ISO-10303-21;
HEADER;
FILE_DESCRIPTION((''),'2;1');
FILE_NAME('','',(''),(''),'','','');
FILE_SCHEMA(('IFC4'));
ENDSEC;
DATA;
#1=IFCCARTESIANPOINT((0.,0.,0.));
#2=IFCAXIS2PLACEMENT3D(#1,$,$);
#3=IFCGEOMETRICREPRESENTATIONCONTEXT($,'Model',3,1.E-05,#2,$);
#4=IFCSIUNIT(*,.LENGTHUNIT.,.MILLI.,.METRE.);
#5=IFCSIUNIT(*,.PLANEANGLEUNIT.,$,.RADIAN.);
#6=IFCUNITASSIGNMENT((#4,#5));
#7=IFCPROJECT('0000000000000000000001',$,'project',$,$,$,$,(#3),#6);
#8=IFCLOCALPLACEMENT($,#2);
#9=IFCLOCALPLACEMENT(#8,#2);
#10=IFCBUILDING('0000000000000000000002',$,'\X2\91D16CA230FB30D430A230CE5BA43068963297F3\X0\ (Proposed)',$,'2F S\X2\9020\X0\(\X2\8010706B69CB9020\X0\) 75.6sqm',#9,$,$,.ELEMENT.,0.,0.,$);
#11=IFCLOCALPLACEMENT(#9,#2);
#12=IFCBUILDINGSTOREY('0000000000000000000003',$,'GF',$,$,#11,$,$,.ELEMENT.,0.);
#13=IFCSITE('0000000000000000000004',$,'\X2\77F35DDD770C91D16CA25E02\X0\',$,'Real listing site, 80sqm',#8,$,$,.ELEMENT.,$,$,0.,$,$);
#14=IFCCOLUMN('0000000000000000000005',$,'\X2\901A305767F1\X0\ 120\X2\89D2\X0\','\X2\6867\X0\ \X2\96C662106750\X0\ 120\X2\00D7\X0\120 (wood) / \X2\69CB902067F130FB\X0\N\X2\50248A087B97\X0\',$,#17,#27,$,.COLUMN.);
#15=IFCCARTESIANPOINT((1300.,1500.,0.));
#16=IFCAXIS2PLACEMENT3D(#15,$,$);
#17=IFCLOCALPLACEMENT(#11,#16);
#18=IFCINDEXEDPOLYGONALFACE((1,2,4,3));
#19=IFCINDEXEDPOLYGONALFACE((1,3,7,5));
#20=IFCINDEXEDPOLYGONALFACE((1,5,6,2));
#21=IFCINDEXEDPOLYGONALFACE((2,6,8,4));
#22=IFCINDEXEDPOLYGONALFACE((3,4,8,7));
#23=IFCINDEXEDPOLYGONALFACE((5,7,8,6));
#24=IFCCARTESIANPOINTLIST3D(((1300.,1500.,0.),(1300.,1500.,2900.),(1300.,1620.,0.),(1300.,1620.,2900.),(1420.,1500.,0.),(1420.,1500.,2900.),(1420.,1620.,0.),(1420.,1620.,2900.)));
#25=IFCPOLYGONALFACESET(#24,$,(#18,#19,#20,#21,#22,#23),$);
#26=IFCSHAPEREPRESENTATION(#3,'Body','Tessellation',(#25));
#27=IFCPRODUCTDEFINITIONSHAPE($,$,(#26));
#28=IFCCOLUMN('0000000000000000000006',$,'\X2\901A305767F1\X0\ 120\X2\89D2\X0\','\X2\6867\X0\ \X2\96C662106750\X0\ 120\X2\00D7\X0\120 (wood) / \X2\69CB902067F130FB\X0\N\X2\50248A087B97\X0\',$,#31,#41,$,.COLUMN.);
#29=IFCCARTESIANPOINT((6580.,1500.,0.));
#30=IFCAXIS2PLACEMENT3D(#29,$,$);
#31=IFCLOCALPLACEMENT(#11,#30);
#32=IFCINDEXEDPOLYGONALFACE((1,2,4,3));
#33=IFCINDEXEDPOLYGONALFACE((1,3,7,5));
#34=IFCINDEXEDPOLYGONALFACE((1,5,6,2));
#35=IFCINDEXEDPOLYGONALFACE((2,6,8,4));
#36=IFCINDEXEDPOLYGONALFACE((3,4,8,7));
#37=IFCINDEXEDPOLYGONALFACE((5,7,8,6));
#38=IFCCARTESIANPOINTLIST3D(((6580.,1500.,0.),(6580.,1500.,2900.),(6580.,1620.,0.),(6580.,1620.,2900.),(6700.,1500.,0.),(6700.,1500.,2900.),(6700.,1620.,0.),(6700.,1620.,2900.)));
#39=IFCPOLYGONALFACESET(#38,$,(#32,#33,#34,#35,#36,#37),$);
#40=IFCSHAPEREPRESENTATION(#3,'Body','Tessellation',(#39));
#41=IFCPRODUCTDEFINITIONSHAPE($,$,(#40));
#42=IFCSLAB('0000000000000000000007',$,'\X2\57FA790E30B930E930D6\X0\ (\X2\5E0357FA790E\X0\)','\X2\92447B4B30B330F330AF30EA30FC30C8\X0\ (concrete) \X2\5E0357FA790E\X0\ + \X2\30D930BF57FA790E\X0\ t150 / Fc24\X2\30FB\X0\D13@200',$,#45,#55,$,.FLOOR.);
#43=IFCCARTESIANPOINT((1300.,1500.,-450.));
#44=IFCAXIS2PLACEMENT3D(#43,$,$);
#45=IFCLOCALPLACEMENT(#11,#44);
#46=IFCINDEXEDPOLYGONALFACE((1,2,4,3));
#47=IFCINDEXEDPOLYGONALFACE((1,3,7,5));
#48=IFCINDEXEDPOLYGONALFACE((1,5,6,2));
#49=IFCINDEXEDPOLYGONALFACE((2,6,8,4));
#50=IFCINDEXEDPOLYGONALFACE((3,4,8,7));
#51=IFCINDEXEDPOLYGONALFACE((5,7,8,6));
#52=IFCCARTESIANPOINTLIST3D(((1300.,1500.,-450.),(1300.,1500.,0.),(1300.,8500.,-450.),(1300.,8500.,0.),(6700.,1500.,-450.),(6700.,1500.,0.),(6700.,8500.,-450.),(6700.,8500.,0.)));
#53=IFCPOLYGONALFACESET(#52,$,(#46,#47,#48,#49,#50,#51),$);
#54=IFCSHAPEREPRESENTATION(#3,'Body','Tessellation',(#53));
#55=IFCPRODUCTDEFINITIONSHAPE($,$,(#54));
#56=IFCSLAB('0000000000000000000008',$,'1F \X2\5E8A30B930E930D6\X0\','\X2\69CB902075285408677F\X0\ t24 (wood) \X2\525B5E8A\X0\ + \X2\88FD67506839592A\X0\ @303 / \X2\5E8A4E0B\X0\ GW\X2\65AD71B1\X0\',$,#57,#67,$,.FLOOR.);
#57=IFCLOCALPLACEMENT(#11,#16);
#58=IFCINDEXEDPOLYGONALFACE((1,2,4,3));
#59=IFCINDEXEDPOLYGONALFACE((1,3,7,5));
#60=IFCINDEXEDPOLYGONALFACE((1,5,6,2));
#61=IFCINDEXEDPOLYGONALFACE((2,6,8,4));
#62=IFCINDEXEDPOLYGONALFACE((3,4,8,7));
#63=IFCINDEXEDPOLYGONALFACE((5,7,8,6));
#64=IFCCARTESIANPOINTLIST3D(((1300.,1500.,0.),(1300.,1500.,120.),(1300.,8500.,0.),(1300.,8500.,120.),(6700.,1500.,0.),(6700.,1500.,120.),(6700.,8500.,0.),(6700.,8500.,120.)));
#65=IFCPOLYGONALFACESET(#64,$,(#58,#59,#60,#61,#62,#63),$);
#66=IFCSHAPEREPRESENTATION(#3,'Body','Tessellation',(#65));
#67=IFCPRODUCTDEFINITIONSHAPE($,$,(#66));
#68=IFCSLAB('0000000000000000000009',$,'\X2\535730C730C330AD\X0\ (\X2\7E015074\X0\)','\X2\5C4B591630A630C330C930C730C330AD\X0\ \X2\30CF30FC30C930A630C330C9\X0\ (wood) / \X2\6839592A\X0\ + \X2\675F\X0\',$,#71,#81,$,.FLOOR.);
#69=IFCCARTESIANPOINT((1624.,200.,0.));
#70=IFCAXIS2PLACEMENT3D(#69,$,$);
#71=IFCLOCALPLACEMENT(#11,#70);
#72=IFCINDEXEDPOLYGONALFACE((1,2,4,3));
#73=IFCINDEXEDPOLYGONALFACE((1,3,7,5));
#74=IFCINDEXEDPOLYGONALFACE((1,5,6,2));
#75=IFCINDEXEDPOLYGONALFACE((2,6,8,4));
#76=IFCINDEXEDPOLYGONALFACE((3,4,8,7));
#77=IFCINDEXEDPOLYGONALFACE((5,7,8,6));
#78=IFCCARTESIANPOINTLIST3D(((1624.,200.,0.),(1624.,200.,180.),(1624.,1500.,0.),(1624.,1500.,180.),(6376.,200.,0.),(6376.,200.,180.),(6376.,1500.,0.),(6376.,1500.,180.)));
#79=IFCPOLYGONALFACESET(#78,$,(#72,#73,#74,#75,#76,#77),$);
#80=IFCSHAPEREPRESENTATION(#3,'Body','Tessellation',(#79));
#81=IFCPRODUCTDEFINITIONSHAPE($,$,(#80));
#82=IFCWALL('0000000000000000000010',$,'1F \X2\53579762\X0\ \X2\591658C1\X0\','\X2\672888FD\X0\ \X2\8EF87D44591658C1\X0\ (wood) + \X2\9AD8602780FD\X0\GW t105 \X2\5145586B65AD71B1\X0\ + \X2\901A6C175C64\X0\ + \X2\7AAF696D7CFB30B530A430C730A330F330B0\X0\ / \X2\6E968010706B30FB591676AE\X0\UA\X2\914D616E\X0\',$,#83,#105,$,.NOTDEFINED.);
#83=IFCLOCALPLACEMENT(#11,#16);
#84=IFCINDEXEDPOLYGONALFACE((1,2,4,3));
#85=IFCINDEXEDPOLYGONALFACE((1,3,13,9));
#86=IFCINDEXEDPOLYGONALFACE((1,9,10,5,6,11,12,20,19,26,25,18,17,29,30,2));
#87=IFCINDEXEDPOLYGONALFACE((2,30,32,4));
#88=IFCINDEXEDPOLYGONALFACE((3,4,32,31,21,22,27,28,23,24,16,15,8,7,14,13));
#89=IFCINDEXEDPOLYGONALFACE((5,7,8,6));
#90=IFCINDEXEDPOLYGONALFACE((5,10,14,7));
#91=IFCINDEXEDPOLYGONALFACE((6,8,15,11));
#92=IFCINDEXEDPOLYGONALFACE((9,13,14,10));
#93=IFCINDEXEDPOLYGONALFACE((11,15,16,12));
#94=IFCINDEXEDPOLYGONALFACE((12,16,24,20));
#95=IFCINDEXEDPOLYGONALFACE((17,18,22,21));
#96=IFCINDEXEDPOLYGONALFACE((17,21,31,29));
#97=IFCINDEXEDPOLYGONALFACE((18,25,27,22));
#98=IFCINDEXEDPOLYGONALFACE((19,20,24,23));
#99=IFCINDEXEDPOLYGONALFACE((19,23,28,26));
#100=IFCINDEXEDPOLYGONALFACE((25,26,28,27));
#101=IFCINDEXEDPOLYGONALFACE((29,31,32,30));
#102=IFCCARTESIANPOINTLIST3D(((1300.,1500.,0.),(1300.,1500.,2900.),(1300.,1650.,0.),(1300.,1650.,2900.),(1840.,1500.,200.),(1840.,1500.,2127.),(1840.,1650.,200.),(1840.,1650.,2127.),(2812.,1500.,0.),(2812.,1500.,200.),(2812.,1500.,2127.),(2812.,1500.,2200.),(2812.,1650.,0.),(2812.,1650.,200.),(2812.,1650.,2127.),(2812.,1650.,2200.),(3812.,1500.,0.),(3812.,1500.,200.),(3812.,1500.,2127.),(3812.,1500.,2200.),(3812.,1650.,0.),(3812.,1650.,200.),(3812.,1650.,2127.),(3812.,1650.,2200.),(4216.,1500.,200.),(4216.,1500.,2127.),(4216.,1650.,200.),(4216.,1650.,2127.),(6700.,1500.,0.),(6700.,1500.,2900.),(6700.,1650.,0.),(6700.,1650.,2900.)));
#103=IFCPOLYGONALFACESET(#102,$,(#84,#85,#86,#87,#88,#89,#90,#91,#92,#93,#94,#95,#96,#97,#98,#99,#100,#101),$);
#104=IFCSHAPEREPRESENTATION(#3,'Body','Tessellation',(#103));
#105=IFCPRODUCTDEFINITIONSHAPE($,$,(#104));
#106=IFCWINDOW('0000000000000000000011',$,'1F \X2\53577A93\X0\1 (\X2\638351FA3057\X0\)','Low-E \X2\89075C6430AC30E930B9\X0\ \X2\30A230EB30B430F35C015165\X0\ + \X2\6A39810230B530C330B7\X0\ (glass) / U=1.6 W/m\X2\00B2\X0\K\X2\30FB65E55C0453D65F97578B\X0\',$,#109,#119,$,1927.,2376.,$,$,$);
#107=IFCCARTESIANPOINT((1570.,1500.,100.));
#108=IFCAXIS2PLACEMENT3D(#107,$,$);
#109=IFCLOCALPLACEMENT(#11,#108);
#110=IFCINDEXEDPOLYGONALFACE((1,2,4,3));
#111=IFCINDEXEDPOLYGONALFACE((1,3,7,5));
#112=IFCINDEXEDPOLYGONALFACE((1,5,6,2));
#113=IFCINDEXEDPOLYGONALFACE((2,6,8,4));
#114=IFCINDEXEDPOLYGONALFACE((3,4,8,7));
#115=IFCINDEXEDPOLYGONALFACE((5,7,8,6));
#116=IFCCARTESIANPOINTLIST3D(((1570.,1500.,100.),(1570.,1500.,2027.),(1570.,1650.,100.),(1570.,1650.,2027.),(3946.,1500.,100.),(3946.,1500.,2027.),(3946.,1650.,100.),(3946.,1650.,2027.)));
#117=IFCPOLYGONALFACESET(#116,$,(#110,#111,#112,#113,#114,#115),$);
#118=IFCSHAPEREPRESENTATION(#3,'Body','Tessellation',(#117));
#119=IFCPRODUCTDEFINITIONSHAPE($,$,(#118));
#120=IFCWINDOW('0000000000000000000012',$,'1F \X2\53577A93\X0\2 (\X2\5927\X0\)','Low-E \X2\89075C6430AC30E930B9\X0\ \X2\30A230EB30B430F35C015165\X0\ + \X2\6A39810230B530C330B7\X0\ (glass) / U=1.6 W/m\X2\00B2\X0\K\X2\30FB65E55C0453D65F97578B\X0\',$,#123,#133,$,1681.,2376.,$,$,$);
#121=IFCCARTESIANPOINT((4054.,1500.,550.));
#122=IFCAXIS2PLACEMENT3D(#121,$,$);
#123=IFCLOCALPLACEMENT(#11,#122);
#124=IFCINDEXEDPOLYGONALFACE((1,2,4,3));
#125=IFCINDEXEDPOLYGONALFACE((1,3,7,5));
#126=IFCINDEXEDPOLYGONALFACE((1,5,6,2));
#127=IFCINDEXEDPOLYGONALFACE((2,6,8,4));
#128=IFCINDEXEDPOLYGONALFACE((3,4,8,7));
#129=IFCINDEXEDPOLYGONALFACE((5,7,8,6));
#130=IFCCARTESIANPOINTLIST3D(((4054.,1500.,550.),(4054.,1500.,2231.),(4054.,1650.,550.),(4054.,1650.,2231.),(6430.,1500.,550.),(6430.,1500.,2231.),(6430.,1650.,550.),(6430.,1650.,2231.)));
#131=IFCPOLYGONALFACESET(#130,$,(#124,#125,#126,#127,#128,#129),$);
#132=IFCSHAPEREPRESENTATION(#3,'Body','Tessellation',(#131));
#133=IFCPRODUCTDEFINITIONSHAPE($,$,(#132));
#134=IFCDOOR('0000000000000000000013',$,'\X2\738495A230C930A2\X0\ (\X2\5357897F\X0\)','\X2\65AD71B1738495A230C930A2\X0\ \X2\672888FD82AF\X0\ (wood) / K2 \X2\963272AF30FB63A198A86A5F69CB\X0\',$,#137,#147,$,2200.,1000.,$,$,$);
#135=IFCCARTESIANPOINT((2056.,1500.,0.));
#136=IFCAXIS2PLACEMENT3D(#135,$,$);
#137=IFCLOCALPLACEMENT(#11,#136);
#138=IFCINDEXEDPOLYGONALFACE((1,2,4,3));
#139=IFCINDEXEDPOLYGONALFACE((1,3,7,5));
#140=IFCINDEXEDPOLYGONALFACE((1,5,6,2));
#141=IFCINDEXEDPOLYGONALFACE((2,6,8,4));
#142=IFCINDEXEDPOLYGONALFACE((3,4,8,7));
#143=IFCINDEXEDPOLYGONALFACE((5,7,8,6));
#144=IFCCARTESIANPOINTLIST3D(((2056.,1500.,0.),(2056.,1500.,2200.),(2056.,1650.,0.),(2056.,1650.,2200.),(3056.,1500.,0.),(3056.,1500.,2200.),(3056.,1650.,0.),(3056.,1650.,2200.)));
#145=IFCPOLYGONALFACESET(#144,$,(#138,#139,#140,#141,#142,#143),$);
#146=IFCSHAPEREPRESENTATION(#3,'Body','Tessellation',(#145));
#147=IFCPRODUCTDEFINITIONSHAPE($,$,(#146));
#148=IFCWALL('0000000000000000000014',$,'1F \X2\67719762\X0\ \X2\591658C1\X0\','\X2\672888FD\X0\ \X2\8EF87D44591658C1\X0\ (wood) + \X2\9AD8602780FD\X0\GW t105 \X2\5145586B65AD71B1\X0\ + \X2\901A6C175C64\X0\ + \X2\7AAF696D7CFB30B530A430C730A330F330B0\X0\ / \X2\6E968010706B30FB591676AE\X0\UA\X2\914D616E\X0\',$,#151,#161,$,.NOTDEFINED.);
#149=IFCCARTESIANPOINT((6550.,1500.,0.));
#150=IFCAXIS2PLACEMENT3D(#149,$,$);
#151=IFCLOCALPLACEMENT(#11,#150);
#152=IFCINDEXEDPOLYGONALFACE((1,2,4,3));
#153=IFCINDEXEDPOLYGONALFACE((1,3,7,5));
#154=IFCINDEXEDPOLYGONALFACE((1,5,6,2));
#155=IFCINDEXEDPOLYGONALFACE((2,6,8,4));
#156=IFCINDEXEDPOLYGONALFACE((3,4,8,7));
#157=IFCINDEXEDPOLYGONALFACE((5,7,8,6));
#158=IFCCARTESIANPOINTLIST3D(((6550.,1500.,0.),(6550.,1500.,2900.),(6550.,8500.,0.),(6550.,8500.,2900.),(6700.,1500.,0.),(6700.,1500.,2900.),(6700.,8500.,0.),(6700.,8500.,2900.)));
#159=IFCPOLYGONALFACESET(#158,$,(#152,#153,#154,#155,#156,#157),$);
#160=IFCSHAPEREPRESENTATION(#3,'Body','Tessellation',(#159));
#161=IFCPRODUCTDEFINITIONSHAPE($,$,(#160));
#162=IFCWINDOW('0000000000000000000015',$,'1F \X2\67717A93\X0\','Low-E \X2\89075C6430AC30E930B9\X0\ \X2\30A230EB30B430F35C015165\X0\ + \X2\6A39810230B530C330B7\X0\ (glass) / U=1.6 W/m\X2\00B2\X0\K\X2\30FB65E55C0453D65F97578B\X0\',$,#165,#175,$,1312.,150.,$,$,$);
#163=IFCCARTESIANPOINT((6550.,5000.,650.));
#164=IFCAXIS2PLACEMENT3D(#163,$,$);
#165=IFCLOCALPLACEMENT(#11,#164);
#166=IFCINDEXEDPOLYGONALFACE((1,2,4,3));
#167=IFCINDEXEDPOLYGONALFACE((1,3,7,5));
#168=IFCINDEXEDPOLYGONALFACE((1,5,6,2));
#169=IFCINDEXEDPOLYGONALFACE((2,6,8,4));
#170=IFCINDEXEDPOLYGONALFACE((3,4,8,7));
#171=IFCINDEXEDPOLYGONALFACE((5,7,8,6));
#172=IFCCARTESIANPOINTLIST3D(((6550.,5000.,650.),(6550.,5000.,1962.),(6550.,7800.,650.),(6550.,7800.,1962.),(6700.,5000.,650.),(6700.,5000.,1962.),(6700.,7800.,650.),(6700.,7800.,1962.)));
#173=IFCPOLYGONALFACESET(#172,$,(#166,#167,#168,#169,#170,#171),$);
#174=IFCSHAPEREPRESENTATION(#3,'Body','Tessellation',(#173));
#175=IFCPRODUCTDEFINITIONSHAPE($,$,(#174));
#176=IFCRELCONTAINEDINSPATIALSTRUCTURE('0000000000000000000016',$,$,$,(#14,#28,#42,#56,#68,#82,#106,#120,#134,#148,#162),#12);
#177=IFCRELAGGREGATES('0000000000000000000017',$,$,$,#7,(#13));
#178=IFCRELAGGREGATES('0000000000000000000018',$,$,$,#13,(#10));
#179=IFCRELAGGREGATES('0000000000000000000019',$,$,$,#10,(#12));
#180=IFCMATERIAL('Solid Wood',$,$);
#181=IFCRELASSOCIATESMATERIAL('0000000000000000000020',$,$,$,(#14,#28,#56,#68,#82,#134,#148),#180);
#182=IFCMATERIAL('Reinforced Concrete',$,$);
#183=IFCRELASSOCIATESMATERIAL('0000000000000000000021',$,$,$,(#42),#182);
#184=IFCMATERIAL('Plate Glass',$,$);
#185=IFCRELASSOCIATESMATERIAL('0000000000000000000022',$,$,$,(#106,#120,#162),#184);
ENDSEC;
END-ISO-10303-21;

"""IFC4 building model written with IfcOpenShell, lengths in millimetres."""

from ifc_helpers import new_model, si_unit, frame, frame_2d, origin, place, context, project, spatial, rectangle, extrude, material, element, fill, save


model = new_model("IFC4")

# Units and contexts
model_context = context("Model", 3, precision=1e-05, world=origin())
ifc_project = project(units=[si_unit("LENGTHUNIT", "METRE", prefix="MILLI"), si_unit("PLANEANGLEUNIT", "RADIAN")], contexts=[model_context])

# Site, building, storey
site_placement = place(None, origin())
site = spatial("IfcSite", under=ifc_project, at=site_placement, Name="石川県金沢市", ObjectType="Real listing site, 80sqm", CompositionType="ELEMENT", RefElevation=0.0)
building_placement = place(site_placement, origin())
building = spatial("IfcBuilding", under=site, at=building_placement, Name="金沢・ピアノ室と防音 (Proposed)", ObjectType="2F S造(耐火構造) 75.6sqm", CompositionType="ELEMENT", ElevationOfRefHeight=0.0, ElevationOfTerrain=0.0)
storey_placement = place(building_placement, origin())
storey = spatial("IfcBuildingStorey", under=building, at=storey_placement, Name="GF", CompositionType="ELEMENT", Elevation=0.0)

# Columns
ifc_material_1 = material(Name="Solid Wood")
column_1_placement = place(storey_placement, frame((1300.0, 1500.0, 0.0)))
element("IfcColumn", 1, at=column_1_placement, inside=storey, material=ifc_material_1, Name="通し柱 120角", Description="桧 集成材 120×120 (wood) / 構造柱・N値計算", PredefinedType="COLUMN", context=model_context, shape_type="SweptSolid", body=[
    extrude(rectangle(XDim=120.0, YDim=120.0, at=frame_2d((60.0, 60.0))), frame((1300.0, 1500.0, 0.0)), (0.0, 0.0, 1.0), 2900.0),
])
column_2_placement = place(storey_placement, frame((6580.0, 1500.0, 0.0)))
element("IfcColumn", 2, at=column_2_placement, inside=storey, material=ifc_material_1, Name="通し柱 120角", Description="桧 集成材 120×120 (wood) / 構造柱・N値計算", PredefinedType="COLUMN", context=model_context, shape_type="SweptSolid", body=[
    extrude(rectangle(XDim=120.0, YDim=120.0, at=frame_2d((60.0, 60.0))), frame((6580.0, 1500.0, 0.0)), (0.0, 0.0, 1.0), 2900.0),
])

# Slabs
ifc_material_2 = material(Name="Reinforced Concrete")
slab_1_placement = place(storey_placement, frame((1300.0, 1500.0, -450.0)))
element("IfcSlab", 3, at=slab_1_placement, inside=storey, material=ifc_material_2, Name="基礎スラブ (布基礎)", Description="鉄筋コンクリート (concrete) 布基礎 + ベタ基礎 t150 / Fc24・D13@200", PredefinedType="FLOOR", context=model_context, shape_type="SweptSolid", body=[
    extrude(rectangle(XDim=5400.0, YDim=7000.0, at=frame_2d((2700.0, 3500.0))), frame((1300.0, 1500.0, -450.0)), (0.0, 0.0, 1.0), 450.0),
])
slab_2_placement = place(storey_placement, frame((1300.0, 1500.0, 0.0)))
element("IfcSlab", 4, at=slab_2_placement, inside=storey, material=ifc_material_1, Name="1F 床スラブ", Description="構造用合板 t24 (wood) 剛床 + 製材根太 @303 / 床下 GW断熱", PredefinedType="FLOOR", context=model_context, shape_type="SweptSolid", body=[
    extrude(rectangle(XDim=5400.0, YDim=7000.0, at=frame_2d((2700.0, 3500.0))), frame((1300.0, 1500.0, 0.0)), (0.0, 0.0, 1.0), 120.0),
])
slab_3_placement = place(storey_placement, frame((1624.0, 200.0, 0.0)))
element("IfcSlab", 5, at=slab_3_placement, inside=storey, material=ifc_material_1, Name="南デッキ (縁側)", Description="屋外ウッドデッキ ハードウッド (wood) / 根太 + 束", PredefinedType="FLOOR", context=model_context, shape_type="SweptSolid", body=[
    extrude(rectangle(XDim=4752.0, YDim=1300.0, at=frame_2d((2376.0, 650.0))), frame((1624.0, 200.0, 0.0)), (0.0, 0.0, 1.0), 180.0),
])

# Wall, openings, windows, door
wall_1_placement = place(storey_placement, frame((1300.0, 1500.0, 0.0)))
wall_1 = element("IfcWall", 6, at=wall_1_placement, inside=storey, material=ifc_material_1, Name="1F 南面 外壁", Description="木製 軸組外壁 (wood) + 高性能GW t105 充填断熱 + 通気層 + 窯業系サイディング / 準耐火・外皮UA配慮", PredefinedType="NOTDEFINED", context=model_context, shape_type="SweptSolid", body=[
    extrude(rectangle(XDim=5400.0, YDim=150.0, at=frame_2d((2700.0, 75.0))), frame((1300.0, 1500.0, 0.0)), (0.0, 0.0, 1.0), 2900.0),
])
opening_1_placement = place(storey_placement, frame((1570.0, 1500.0, 100.0)))
opening_1 = element("IfcOpeningElement", 7, at=opening_1_placement, cuts=wall_1, PredefinedType="NOTDEFINED", context=model_context, shape_type="SweptSolid", body=[
    extrude(rectangle(XDim=2376.0, YDim=150.0, at=frame_2d((1188.0, 75.0))), frame((1570.0, 1500.0, 100.0)), (0.0, 0.0, 1.0), 1927.0),
])
opening_2_placement = place(storey_placement, frame((4054.0, 1500.0, 550.0)))
opening_2 = element("IfcOpeningElement", 8, at=opening_2_placement, cuts=wall_1, PredefinedType="NOTDEFINED", context=model_context, shape_type="SweptSolid", body=[
    extrude(rectangle(XDim=2376.0, YDim=150.0, at=frame_2d((1188.0, 75.0))), frame((4054.0, 1500.0, 550.0)), (0.0, 0.0, 1.0), 1681.0),
])
opening_3_placement = place(storey_placement, frame((2056.0, 1500.0, 0.0)))
opening_3 = element("IfcOpeningElement", 9, at=opening_3_placement, cuts=wall_1, PredefinedType="NOTDEFINED", context=model_context, shape_type="SweptSolid", body=[
    extrude(rectangle(XDim=1000.0, YDim=150.0, at=frame_2d((500.0, 75.0))), frame((2056.0, 1500.0, 0.0)), (0.0, 0.0, 1.0), 2200.0),
])
ifc_material_3 = material(Name="Plate Glass")
window_1_placement = place(storey_placement, frame((1570.0, 1500.0, 100.0)))
window_1 = element("IfcWindow", 10, at=window_1_placement, inside=storey, material=ifc_material_3, Name="1F 南窓1 (掃出し)", Description="Low-E 複層ガラス アルゴン封入 + 樹脂サッシ (glass) / U=1.6 W/m²K・日射取得型", OverallHeight=1927.0, OverallWidth=2376.0, context=model_context, shape_type="SweptSolid", body=[
    extrude(rectangle(XDim=2376.0, YDim=150.0, at=frame_2d((1188.0, 75.0))), frame((1570.0, 1500.0, 100.0)), (0.0, 0.0, 1.0), 1927.0),
])
fill(opening_1, window_1)
window_2_placement = place(storey_placement, frame((4054.0, 1500.0, 550.0)))
window_2 = element("IfcWindow", 11, at=window_2_placement, inside=storey, material=ifc_material_3, Name="1F 南窓2 (大)", Description="Low-E 複層ガラス アルゴン封入 + 樹脂サッシ (glass) / U=1.6 W/m²K・日射取得型", OverallHeight=1681.0, OverallWidth=2376.0, context=model_context, shape_type="SweptSolid", body=[
    extrude(rectangle(XDim=2376.0, YDim=150.0, at=frame_2d((1188.0, 75.0))), frame((4054.0, 1500.0, 550.0)), (0.0, 0.0, 1.0), 1681.0),
])
fill(opening_2, window_2)
door_placement = place(storey_placement, frame((2056.0, 1500.0, 0.0)))
door = element("IfcDoor", 12, at=door_placement, inside=storey, material=ifc_material_1, Name="玄関ドア (南西)", Description="断熱玄関ドア 木製芯 (wood) / K2 防犯・採風機構", OverallHeight=2200.0, OverallWidth=1000.0, context=model_context, shape_type="SweptSolid", body=[
    extrude(rectangle(XDim=1000.0, YDim=150.0, at=frame_2d((500.0, 75.0))), frame((2056.0, 1500.0, 0.0)), (0.0, 0.0, 1.0), 2200.0),
])
fill(opening_3, door)

# Wall, opening, window
wall_2_placement = place(storey_placement, frame((6550.0, 1500.0, 0.0)))
wall_2 = element("IfcWall", 13, at=wall_2_placement, inside=storey, material=ifc_material_1, Name="1F 東面 外壁", Description="木製 軸組外壁 (wood) + 高性能GW t105 充填断熱 + 通気層 + 窯業系サイディング / 準耐火・外皮UA配慮", PredefinedType="NOTDEFINED", context=model_context, shape_type="SweptSolid", body=[
    extrude(rectangle(XDim=150.0, YDim=7000.0, at=frame_2d((75.0, 3500.0))), frame((6550.0, 1500.0, 0.0)), (0.0, 0.0, 1.0), 2900.0),
])
opening_4_placement = place(storey_placement, frame((6550.0, 5000.0, 650.0)))
opening_4 = element("IfcOpeningElement", 14, at=opening_4_placement, cuts=wall_2, PredefinedType="NOTDEFINED", context=model_context, shape_type="SweptSolid", body=[
    extrude(rectangle(XDim=150.0, YDim=2800.0, at=frame_2d((75.0, 1400.0))), frame((6550.0, 5000.0, 650.0)), (0.0, 0.0, 1.0), 1312.0),
])
window_3_placement = place(storey_placement, frame((6550.0, 5000.0, 650.0)))
window_3 = element("IfcWindow", 15, at=window_3_placement, inside=storey, material=ifc_material_3, Name="1F 東窓", Description="Low-E 複層ガラス アルゴン封入 + 樹脂サッシ (glass) / U=1.6 W/m²K・日射取得型", OverallHeight=1312.0, OverallWidth=150.0, context=model_context, shape_type="SweptSolid", body=[
    extrude(rectangle(XDim=150.0, YDim=2800.0, at=frame_2d((75.0, 1400.0))), frame((6550.0, 5000.0, 650.0)), (0.0, 0.0, 1.0), 1312.0),
])
fill(opening_4, window_3)

save(model, "model.ifc")
